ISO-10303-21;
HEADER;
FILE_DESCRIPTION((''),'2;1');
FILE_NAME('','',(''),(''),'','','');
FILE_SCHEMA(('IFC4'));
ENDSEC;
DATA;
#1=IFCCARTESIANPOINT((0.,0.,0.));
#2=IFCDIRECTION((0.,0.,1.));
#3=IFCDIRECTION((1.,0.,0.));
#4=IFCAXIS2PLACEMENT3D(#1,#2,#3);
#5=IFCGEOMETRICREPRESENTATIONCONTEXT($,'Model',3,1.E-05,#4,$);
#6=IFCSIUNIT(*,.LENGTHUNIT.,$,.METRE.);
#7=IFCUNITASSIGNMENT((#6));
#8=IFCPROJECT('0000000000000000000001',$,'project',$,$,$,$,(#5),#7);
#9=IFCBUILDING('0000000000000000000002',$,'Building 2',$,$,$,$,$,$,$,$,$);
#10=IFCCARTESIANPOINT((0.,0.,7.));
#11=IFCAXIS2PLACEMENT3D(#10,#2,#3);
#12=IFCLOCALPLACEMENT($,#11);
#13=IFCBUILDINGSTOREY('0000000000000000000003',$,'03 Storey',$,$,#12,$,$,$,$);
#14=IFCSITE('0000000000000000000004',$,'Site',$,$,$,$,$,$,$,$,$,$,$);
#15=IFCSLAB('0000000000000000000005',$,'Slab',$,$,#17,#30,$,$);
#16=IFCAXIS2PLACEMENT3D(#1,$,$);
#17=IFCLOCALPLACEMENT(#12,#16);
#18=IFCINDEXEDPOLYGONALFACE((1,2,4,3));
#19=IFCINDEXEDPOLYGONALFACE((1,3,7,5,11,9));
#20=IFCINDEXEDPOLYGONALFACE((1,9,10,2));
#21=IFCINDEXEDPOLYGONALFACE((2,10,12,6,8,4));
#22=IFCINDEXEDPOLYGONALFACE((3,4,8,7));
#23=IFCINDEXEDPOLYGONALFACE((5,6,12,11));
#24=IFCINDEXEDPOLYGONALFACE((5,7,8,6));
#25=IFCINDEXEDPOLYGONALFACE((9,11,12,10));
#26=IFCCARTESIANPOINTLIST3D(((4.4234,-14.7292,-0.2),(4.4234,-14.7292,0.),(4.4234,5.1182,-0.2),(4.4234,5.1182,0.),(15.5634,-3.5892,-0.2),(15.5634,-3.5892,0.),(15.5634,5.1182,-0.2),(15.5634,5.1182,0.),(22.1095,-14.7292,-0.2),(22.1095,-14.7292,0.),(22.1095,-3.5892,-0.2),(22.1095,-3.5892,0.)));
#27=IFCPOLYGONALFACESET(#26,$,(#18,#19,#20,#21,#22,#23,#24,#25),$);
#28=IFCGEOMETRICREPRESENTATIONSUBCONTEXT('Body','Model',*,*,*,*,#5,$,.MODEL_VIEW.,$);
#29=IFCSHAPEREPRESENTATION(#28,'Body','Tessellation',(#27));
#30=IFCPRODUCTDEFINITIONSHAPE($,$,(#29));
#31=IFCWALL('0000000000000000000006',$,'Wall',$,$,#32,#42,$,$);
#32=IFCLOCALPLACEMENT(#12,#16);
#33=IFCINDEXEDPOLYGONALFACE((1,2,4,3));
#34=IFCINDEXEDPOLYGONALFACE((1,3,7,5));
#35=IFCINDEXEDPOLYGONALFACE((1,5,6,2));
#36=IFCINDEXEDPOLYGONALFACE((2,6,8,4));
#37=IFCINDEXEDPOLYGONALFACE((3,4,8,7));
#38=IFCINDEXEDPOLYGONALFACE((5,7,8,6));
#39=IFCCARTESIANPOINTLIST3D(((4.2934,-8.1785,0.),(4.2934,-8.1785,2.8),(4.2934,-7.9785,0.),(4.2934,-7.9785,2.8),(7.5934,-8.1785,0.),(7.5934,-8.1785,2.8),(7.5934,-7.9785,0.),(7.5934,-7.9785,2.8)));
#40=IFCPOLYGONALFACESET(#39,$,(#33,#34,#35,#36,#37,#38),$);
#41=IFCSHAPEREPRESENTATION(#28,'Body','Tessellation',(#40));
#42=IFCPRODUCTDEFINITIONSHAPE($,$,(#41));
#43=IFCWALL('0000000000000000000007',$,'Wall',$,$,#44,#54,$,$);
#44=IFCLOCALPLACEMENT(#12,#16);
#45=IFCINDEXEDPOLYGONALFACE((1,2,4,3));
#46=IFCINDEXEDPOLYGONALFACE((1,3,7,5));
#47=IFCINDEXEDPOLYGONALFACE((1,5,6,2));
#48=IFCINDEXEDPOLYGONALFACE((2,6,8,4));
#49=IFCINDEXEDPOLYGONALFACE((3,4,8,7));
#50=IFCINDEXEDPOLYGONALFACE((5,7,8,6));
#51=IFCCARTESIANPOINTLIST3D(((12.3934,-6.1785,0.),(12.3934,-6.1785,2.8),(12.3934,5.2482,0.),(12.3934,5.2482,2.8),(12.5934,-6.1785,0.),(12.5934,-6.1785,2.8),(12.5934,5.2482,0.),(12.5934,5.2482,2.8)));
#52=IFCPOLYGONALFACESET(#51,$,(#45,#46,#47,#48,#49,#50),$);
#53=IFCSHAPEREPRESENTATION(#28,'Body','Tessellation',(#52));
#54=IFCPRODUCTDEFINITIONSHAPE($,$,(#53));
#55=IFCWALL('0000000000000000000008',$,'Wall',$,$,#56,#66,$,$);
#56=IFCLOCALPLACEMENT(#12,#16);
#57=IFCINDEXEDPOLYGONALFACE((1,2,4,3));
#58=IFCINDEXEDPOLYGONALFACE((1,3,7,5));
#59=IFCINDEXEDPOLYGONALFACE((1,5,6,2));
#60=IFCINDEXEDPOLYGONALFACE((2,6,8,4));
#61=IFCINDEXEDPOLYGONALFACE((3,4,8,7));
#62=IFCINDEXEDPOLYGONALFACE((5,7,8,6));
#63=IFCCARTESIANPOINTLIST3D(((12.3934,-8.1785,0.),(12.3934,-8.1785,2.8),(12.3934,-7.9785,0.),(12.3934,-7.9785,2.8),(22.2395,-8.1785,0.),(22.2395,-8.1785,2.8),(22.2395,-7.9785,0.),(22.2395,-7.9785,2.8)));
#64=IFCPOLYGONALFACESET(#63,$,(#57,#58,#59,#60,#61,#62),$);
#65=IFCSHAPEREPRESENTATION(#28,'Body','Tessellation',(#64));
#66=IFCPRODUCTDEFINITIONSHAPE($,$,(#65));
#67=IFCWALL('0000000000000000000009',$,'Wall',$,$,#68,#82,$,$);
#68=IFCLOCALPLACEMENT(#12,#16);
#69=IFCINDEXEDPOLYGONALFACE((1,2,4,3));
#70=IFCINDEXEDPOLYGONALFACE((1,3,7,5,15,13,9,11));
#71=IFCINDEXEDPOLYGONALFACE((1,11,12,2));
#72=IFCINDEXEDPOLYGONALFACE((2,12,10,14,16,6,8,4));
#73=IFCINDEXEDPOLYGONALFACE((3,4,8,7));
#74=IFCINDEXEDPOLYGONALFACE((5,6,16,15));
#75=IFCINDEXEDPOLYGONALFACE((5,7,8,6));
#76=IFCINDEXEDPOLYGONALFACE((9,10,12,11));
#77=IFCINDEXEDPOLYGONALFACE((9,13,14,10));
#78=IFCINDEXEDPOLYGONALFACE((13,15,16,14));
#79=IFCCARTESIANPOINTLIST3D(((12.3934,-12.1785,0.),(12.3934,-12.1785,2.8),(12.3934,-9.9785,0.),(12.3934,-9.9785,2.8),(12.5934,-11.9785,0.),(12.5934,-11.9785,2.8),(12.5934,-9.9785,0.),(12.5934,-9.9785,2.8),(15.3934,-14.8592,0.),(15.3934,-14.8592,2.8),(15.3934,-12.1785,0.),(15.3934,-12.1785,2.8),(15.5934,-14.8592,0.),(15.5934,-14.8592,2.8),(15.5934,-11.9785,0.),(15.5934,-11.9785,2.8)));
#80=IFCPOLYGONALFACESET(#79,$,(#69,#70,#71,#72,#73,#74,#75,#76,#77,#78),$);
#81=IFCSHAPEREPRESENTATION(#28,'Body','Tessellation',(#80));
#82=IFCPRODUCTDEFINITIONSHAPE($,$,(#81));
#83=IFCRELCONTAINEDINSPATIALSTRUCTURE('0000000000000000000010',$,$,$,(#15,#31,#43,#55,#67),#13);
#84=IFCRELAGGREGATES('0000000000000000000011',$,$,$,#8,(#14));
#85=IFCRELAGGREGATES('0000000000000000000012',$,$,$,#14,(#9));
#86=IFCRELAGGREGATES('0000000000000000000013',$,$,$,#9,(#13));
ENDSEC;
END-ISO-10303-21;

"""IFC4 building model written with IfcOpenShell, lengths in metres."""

from ifc_helpers import new_model, si_unit, frame, origin_with_axes, place, context, subcontext, project, spatial, line, indexed_curve, outline, extrude, element, save


model = new_model("IFC4")

# Units and contexts
model_context = context("Model", 3, precision=1e-05, world=origin_with_axes())
body_context = subcontext(model_context, "Body", "Model", "MODEL_VIEW")
ifc_project = project(units=[si_unit("LENGTHUNIT", "METRE")], contexts=[model_context])

# Site, building, storey
site = spatial("IfcSite", under=ifc_project, Name="Site")
building = spatial("IfcBuilding", under=site, Name="Building 2")
storey_placement = place(None, frame((0.0, 0.0, 7.0), z_axis=(0.0, 0.0, 1.0), x_axis=(1.0, 0.0, 0.0)))
storey = spatial("IfcBuildingStorey", under=building, at=storey_placement, Name="03 Storey")

# Slab
slab_placement = place(storey_placement, origin_with_axes())
element("IfcSlab", 1, at=slab_placement, inside=storey, Name="Slab", context=body_context, shape_type="SweptSolid", body=[
    extrude(outline(indexed_curve([(22.1095, -3.5892), (15.5634, -3.5892), (15.5634, 5.1182), (4.4234, 5.1182), (4.4234, -14.7292), (22.1095, -14.7292)], segments=[line(1, 2), line(2, 3), line(3, 4), line(4, 5), line(5, 6)])), origin_with_axes(), (0.0, 0.0, -1.0), 0.2),
])

# Walls
wall_1_placement = place(storey_placement, origin_with_axes())
element("IfcWall", 2, at=wall_1_placement, inside=storey, Name="Wall", context=body_context, shape_type="SweptSolid", body=[
    extrude(outline(indexed_curve([(7.5934, -7.9785), (4.2934, -7.9785), (4.2934, -8.1785), (7.5934, -8.1785)], segments=[line(1, 2), line(2, 3), line(3, 4)])), origin_with_axes(), (0.0, 0.0, 1.0), 2.8),
])
wall_2_placement = place(storey_placement, origin_with_axes())
element("IfcWall", 3, at=wall_2_placement, inside=storey, Name="Wall", context=body_context, shape_type="SweptSolid", body=[
    extrude(outline(indexed_curve([(12.5934, 5.2482), (12.3934, 5.2482), (12.3934, -6.1785), (12.5934, -6.1785)], segments=[line(1, 2), line(2, 3), line(3, 4)])), origin_with_axes(), (0.0, 0.0, 1.0), 2.8),
])
wall_3_placement = place(storey_placement, origin_with_axes())
element("IfcWall", 4, at=wall_3_placement, inside=storey, Name="Wall", context=body_context, shape_type="SweptSolid", body=[
    extrude(outline(indexed_curve([(22.2395, -7.9785), (12.3934, -7.9785), (12.3934, -8.1785), (22.2395, -8.1785)], segments=[line(1, 2), line(2, 3), line(3, 4)])), origin_with_axes(), (0.0, 0.0, 1.0), 2.8),
])
wall_4_placement = place(storey_placement, origin_with_axes())
element("IfcWall", 5, at=wall_4_placement, inside=storey, Name="Wall", context=body_context, shape_type="SweptSolid", body=[
    extrude(outline(indexed_curve([(15.5934, -11.9785), (12.5934, -11.9785), (12.5934, -9.9785), (12.3934, -9.9785), (12.3934, -12.1785), (15.3934, -12.1785), (15.3934, -14.8592), (15.5934, -14.8592)], segments=[line(1, 2), line(2, 3), line(3, 4), line(4, 5), line(5, 6), line(6, 7), line(7, 8)])), origin_with_axes(), (0.0, 0.0, 1.0), 2.8),
])

save(model, "model.ifc")
